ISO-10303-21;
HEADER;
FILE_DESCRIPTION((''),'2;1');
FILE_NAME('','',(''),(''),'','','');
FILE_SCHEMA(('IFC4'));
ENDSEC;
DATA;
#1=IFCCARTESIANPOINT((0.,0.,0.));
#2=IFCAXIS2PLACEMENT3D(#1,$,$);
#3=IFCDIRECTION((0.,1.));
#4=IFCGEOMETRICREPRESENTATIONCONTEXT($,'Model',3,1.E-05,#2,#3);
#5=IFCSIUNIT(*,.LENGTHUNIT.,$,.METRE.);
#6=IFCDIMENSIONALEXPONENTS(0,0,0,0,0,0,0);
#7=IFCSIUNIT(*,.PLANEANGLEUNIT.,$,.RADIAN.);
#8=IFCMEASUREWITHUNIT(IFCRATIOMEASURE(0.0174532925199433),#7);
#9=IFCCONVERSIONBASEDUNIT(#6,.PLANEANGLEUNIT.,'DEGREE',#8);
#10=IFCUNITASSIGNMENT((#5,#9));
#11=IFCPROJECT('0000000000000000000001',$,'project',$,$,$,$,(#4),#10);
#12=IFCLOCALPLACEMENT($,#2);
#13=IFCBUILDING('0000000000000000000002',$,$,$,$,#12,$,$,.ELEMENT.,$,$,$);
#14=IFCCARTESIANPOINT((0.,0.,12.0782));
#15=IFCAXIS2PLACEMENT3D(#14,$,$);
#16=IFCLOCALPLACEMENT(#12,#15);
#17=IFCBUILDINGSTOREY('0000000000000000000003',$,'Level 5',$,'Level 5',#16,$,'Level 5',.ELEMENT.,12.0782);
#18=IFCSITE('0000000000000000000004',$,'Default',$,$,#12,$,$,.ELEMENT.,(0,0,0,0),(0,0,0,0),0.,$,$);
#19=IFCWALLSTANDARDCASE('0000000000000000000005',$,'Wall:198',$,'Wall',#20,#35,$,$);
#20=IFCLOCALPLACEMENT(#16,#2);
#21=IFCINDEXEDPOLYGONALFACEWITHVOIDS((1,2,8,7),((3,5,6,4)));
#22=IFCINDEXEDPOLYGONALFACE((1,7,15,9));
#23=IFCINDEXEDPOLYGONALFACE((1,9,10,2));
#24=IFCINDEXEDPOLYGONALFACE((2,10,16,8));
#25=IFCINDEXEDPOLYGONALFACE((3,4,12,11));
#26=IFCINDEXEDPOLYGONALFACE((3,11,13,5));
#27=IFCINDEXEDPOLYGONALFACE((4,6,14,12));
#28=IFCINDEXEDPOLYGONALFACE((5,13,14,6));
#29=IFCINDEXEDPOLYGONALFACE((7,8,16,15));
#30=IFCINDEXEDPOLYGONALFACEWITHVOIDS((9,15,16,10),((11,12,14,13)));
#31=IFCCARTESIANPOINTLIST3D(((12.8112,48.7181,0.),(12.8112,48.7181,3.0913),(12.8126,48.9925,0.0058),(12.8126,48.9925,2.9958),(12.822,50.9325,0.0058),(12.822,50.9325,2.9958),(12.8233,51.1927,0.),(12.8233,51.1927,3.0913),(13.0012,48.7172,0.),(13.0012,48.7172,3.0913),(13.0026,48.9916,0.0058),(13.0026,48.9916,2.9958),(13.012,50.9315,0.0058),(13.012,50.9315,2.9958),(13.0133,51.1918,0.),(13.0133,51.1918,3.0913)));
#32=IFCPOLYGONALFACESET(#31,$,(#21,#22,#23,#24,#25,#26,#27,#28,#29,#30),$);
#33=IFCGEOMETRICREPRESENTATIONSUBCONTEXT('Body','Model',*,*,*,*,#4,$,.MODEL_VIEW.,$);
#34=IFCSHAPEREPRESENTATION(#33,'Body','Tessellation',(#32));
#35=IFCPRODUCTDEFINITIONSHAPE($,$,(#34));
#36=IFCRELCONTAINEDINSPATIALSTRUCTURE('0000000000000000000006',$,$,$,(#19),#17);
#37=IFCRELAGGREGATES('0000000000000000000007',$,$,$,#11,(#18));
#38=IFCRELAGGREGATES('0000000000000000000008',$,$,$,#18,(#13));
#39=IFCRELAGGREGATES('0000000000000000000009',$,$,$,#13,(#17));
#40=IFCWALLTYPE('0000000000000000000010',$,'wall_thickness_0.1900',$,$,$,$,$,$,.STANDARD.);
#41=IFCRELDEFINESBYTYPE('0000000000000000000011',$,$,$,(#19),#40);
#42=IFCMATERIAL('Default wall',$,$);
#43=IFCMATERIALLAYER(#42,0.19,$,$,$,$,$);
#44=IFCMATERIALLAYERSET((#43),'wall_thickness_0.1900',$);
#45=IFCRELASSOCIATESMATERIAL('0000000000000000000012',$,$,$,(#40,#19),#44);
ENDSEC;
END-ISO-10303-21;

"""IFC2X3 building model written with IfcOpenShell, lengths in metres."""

from ifc_helpers import new_model, entity, si_unit, converted_unit, direction, frame, frame_2d, origin, place, context, subcontext, project, spatial, polyline, rectangle, outline, extrude, clip, halfspace, material, layer, layer_set, layer_usage, type_object, element, save


model = new_model("IFC2X3")

# Units and contexts
model_context = context("Model", 3, precision=1e-05, world=origin(), true_north=direction((0.0, 1.0)))
body_context = subcontext(model_context, "Body", "Model", "MODEL_VIEW")
ifc_project = project(units=[si_unit("LENGTHUNIT", "METRE"), converted_unit("PLANEANGLEUNIT", "DEGREE", entity("IfcRatioMeasure", 0.0174532925199433), si_unit("PLANEANGLEUNIT", "RADIAN"), dimensions=[0, 0, 0, 0, 0, 0, 0])], contexts=[model_context])

# Site, building, storey
placement_1 = place(None, origin())
site = spatial("IfcSite", under=ifc_project, at=placement_1, Name="Default", CompositionType="ELEMENT", RefLatitude=(0, 0, 0, 0), RefLongitude=(0, 0, 0, 0), RefElevation=0.0)
building = spatial("IfcBuilding", under=site, at=placement_1, CompositionType="ELEMENT")
storey_placement = place(placement_1, frame((0.0, 0.0, 12.0782)))
storey = spatial("IfcBuildingStorey", under=building, at=storey_placement, Name="Level 5", ObjectType="Level 5", LongName="Level 5", CompositionType="ELEMENT", Elevation=12.0782)

# Shared definitions
ifc_material_1 = material(Name="Default wall")

# Wall, opening
ifc_layer_1 = layer(ifc_material_1, 0.19)
ifc_layer_set_1 = layer_set([ifc_layer_1], Name="wall_thickness_0.1900")
ifc_layer_usage_1 = layer_usage(ifc_layer_set_1, "AXIS2", "POSITIVE", -0.095)
wall_type_1 = type_object("IfcWallType", Name="wall_thickness_0.1900", PredefinedType="STANDARD", material=ifc_layer_set_1)
wall_1_placement = place(storey_placement, frame((12.9183, 51.1923, 0.0), z_axis=(0.0, 0.0, 1.0), x_axis=(-0.004871, -0.999988, 0.0)))
wall_1 = element("IfcWallStandardCase", 1, at=wall_1_placement, inside=storey, type_object=wall_type_1, material=ifc_layer_usage_1, Name="Wall:198", ObjectType="Wall", context=body_context, shape_type="Clipping", body=[
    clip(extrude(outline(polyline([(2.4746, -0.095), (2.4746, 0.095), (0.0, 0.095), (0.0, -0.095), (2.4746, -0.095)])), origin(), (0.0, 0.0, 1.0), 3.0913), halfspace(frame((-26.0467, 1.037, 5.8218), z_axis=(0.000002, 0.390505, 0.920601), x_axis=(0.000492, -0.920601, 0.390505)), False)),
])
opening_1_placement = place(wall_1_placement, frame((0.2603, -0.095, 0.0058)))
element("IfcOpeningElement", 2, at=opening_1_placement, cuts=wall_1, ObjectType="Opening", context=body_context, shape_type="SweptSolid", body=[
    extrude(rectangle(XDim=1.94, YDim=2.99, at=frame_2d((1.495, 0.97), x_axis=(0.0, 1.0))), frame((0.0, 0.0, 0.0), z_axis=(0.0, 1.0, 0.0), x_axis=(0.0, 0.0, 1.0)), (0.0, 0.0, 1.0), 0.19),
])

save(model, "model.ifc")
